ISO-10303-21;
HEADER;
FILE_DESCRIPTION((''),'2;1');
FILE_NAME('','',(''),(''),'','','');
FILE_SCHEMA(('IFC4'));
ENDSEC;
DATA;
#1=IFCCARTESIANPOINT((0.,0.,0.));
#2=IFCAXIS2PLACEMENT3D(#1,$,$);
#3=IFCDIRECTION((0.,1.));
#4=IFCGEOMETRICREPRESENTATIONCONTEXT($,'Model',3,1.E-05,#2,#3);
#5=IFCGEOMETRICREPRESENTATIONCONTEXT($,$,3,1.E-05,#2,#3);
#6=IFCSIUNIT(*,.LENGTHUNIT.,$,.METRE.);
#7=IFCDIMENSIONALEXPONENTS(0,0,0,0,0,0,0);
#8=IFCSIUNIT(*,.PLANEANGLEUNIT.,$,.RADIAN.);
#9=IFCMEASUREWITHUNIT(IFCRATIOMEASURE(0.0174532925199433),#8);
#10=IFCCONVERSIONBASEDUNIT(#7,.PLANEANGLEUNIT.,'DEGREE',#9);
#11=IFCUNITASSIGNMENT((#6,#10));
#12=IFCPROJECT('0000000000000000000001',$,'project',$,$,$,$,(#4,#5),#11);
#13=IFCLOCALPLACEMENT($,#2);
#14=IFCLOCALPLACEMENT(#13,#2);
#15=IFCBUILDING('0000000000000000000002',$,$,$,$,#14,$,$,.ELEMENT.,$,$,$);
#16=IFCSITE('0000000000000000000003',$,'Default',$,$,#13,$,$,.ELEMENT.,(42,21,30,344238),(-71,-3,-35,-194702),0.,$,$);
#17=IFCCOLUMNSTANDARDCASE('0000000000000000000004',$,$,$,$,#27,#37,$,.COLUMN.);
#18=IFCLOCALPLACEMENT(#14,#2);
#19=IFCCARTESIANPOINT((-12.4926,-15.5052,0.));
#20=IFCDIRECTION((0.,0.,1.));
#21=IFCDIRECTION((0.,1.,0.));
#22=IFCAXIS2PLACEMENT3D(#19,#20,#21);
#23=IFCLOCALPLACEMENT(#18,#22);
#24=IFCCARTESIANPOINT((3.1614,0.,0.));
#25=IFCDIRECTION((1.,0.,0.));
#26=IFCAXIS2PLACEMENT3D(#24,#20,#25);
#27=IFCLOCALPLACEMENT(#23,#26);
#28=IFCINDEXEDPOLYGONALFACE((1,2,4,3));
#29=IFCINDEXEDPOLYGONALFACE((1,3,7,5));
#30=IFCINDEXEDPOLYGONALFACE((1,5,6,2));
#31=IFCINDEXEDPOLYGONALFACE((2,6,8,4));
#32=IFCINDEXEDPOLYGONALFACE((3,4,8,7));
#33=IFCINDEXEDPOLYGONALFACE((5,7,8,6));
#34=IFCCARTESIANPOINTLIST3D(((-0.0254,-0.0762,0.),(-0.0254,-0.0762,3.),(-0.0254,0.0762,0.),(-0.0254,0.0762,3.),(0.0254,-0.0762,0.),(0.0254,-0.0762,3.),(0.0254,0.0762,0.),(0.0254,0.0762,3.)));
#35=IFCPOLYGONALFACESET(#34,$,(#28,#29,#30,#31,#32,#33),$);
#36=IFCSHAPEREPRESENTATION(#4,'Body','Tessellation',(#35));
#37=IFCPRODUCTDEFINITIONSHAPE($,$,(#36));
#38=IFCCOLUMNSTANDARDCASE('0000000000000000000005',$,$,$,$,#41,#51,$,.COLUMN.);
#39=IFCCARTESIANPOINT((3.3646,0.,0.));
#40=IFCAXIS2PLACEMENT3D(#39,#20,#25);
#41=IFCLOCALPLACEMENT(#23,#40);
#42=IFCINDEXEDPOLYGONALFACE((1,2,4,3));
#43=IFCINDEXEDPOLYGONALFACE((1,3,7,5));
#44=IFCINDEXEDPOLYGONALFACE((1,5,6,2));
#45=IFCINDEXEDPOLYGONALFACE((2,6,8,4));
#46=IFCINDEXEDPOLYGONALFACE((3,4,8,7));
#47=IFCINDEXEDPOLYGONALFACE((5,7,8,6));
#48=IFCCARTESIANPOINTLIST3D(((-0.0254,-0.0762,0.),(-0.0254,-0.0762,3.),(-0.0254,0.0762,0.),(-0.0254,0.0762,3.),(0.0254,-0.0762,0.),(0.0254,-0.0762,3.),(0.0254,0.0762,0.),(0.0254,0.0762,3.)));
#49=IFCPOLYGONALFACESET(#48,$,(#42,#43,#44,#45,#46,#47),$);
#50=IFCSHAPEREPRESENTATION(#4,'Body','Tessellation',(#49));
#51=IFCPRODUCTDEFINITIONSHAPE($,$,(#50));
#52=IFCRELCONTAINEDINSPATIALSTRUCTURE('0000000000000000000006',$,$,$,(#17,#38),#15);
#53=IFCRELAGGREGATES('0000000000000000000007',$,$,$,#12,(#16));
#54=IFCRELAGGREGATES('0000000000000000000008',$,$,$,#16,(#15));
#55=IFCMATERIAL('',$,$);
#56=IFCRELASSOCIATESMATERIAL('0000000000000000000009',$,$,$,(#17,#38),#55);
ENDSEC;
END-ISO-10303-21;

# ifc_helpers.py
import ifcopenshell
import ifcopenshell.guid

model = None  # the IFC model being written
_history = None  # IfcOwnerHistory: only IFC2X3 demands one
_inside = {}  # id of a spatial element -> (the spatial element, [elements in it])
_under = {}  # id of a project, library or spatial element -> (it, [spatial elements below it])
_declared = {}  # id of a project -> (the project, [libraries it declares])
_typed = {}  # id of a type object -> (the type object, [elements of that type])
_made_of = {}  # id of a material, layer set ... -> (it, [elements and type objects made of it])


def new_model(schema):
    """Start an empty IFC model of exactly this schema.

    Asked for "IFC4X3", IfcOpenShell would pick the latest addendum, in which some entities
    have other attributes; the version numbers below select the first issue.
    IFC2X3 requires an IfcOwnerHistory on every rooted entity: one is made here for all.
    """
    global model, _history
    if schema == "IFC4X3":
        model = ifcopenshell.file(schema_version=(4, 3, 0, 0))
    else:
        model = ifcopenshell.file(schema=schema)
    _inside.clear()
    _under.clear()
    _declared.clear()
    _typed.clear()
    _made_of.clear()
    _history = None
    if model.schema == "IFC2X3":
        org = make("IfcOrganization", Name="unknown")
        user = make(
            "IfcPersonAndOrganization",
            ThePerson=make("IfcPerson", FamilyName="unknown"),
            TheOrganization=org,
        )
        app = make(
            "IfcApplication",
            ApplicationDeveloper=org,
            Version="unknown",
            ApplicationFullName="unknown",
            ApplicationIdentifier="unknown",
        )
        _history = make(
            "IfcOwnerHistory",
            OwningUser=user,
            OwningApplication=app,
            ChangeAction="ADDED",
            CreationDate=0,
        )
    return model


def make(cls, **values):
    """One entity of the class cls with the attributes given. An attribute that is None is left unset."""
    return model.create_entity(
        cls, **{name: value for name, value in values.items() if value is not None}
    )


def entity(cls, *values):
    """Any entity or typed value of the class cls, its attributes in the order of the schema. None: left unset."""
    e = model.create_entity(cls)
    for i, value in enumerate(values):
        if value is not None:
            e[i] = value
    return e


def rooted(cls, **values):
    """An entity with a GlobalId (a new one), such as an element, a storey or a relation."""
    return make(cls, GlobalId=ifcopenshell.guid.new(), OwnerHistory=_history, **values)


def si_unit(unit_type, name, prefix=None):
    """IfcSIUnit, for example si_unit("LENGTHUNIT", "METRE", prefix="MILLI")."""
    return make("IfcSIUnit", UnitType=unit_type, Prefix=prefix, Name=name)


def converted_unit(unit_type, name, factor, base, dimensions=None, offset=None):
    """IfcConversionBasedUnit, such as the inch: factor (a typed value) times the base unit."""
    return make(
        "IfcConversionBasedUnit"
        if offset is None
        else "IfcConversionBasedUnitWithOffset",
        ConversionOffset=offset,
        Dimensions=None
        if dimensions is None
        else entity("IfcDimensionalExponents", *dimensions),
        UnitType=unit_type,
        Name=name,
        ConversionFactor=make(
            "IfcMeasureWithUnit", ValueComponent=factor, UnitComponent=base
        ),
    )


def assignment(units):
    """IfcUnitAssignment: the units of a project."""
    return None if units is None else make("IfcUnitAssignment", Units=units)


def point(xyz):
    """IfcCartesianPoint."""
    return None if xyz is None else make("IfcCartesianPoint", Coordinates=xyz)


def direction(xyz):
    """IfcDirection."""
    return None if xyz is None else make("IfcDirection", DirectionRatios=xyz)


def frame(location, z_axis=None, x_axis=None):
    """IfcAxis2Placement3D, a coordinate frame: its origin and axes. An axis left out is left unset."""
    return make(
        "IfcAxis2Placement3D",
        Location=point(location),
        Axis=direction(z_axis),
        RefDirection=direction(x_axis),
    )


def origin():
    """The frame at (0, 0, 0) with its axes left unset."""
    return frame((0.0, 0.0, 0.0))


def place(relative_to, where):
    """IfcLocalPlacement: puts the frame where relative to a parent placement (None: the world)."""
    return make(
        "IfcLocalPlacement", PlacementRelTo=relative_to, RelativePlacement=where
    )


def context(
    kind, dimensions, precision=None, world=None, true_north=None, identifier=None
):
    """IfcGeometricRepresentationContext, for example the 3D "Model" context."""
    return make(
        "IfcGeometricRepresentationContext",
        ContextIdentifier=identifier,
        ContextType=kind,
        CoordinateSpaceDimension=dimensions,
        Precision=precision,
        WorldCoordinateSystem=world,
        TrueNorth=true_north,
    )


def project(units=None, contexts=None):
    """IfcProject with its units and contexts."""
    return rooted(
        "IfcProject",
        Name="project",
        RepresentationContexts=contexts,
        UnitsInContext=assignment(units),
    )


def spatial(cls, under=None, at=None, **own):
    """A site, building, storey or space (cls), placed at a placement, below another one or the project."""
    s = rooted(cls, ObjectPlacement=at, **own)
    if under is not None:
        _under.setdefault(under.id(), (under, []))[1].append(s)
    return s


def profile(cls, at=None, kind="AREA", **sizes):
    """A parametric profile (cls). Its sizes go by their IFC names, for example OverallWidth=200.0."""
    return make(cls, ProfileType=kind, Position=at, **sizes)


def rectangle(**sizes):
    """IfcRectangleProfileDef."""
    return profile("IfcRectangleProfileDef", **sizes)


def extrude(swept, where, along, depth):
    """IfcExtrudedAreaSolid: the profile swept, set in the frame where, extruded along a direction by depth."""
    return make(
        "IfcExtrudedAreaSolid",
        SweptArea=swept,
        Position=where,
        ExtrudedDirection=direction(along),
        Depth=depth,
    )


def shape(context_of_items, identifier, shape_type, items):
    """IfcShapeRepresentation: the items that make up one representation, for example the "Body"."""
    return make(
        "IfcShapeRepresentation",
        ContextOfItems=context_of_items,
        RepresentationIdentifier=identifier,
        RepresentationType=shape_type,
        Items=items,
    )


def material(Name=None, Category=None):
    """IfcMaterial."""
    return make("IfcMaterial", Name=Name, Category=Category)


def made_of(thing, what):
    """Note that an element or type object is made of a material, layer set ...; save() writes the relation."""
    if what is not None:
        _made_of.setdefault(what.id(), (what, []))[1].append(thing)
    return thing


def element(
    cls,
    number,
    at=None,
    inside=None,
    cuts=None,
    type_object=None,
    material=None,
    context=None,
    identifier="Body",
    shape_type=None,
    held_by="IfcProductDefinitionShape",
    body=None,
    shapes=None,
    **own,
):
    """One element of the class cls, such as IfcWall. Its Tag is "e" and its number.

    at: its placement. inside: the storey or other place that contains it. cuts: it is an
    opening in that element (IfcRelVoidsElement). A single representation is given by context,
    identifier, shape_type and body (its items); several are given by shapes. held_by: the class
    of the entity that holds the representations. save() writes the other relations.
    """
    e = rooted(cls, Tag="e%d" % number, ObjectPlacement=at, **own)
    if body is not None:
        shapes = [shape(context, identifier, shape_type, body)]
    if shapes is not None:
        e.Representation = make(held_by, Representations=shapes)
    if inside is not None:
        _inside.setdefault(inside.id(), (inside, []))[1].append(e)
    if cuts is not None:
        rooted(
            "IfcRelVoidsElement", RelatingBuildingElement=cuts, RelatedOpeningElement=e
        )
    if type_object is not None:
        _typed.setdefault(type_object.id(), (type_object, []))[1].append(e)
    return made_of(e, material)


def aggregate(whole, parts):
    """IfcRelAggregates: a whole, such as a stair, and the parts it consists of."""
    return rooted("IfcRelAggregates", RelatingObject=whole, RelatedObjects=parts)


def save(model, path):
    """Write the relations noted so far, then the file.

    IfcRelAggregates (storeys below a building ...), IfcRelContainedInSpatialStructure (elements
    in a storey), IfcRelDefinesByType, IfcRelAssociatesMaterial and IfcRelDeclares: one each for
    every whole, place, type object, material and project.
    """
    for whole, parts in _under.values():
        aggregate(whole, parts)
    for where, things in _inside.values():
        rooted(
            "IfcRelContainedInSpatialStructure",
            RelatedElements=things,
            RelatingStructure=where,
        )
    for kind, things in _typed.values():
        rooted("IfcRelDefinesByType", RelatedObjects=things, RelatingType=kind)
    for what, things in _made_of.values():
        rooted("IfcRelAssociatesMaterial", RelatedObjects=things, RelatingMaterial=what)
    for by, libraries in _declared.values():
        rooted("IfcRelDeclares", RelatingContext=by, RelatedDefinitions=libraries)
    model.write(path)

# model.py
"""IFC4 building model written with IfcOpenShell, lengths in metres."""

from ifc_helpers import new_model, entity, si_unit, converted_unit, direction, frame, origin, place, context, project, spatial, rectangle, extrude, material, element, save


model = new_model("IFC4")

# Units and contexts
model_context = context("Model", 3, precision=1e-05, world=origin(), true_north=direction((0.0, 1.0)))
context_of_model = context(None, 3, precision=1e-05, world=origin(), true_north=direction((0.0, 1.0)))
ifc_project = project(units=[si_unit("LENGTHUNIT", "METRE"), converted_unit("PLANEANGLEUNIT", "DEGREE", entity("IfcRatioMeasure", 0.0174532925199433), si_unit("PLANEANGLEUNIT", "RADIAN"), dimensions=[0, 0, 0, 0, 0, 0, 0])], contexts=[model_context, context_of_model])

# Site, building
site_placement = place(None, origin())
site = spatial("IfcSite", under=ifc_project, at=site_placement, Name="Default", CompositionType="ELEMENT", RefLatitude=(42, 21, 30, 344238), RefLongitude=(-71, -3, -35, -194702), RefElevation=0.0)
building_placement = place(site_placement, origin())
building = spatial("IfcBuilding", under=site, at=building_placement, CompositionType="ELEMENT")

# Columns
placement_1 = place(building_placement, origin())
ifc_material_1 = material(Name="")
placement_2 = place(placement_1, frame((-12.4926, -15.5052, 0.0), z_axis=(0.0, 0.0, 1.0), x_axis=(0.0, 1.0, 0.0)))
for number, where, z_axis, x_axis in (
    (1, (3.1614, 0.0, 0.0), (0.0, 0.0, 1.0), (1.0, 0.0, 0.0)),
    (2, (3.3646, 0.0, 0.0), (0.0, 0.0, 1.0), (1.0, 0.0, 0.0)),
):
    element("IfcColumnStandardCase", number, at=place(placement_2, frame(where, z_axis=z_axis, x_axis=x_axis)), inside=building, material=ifc_material_1, PredefinedType="COLUMN", context=model_context, shape_type="SweptSolid", body=[
        extrude(rectangle(XDim=0.0508, YDim=0.1524), origin(), (0.0, 0.0, 1.0), 3.0),
    ])

save(model, "model.ifc")
